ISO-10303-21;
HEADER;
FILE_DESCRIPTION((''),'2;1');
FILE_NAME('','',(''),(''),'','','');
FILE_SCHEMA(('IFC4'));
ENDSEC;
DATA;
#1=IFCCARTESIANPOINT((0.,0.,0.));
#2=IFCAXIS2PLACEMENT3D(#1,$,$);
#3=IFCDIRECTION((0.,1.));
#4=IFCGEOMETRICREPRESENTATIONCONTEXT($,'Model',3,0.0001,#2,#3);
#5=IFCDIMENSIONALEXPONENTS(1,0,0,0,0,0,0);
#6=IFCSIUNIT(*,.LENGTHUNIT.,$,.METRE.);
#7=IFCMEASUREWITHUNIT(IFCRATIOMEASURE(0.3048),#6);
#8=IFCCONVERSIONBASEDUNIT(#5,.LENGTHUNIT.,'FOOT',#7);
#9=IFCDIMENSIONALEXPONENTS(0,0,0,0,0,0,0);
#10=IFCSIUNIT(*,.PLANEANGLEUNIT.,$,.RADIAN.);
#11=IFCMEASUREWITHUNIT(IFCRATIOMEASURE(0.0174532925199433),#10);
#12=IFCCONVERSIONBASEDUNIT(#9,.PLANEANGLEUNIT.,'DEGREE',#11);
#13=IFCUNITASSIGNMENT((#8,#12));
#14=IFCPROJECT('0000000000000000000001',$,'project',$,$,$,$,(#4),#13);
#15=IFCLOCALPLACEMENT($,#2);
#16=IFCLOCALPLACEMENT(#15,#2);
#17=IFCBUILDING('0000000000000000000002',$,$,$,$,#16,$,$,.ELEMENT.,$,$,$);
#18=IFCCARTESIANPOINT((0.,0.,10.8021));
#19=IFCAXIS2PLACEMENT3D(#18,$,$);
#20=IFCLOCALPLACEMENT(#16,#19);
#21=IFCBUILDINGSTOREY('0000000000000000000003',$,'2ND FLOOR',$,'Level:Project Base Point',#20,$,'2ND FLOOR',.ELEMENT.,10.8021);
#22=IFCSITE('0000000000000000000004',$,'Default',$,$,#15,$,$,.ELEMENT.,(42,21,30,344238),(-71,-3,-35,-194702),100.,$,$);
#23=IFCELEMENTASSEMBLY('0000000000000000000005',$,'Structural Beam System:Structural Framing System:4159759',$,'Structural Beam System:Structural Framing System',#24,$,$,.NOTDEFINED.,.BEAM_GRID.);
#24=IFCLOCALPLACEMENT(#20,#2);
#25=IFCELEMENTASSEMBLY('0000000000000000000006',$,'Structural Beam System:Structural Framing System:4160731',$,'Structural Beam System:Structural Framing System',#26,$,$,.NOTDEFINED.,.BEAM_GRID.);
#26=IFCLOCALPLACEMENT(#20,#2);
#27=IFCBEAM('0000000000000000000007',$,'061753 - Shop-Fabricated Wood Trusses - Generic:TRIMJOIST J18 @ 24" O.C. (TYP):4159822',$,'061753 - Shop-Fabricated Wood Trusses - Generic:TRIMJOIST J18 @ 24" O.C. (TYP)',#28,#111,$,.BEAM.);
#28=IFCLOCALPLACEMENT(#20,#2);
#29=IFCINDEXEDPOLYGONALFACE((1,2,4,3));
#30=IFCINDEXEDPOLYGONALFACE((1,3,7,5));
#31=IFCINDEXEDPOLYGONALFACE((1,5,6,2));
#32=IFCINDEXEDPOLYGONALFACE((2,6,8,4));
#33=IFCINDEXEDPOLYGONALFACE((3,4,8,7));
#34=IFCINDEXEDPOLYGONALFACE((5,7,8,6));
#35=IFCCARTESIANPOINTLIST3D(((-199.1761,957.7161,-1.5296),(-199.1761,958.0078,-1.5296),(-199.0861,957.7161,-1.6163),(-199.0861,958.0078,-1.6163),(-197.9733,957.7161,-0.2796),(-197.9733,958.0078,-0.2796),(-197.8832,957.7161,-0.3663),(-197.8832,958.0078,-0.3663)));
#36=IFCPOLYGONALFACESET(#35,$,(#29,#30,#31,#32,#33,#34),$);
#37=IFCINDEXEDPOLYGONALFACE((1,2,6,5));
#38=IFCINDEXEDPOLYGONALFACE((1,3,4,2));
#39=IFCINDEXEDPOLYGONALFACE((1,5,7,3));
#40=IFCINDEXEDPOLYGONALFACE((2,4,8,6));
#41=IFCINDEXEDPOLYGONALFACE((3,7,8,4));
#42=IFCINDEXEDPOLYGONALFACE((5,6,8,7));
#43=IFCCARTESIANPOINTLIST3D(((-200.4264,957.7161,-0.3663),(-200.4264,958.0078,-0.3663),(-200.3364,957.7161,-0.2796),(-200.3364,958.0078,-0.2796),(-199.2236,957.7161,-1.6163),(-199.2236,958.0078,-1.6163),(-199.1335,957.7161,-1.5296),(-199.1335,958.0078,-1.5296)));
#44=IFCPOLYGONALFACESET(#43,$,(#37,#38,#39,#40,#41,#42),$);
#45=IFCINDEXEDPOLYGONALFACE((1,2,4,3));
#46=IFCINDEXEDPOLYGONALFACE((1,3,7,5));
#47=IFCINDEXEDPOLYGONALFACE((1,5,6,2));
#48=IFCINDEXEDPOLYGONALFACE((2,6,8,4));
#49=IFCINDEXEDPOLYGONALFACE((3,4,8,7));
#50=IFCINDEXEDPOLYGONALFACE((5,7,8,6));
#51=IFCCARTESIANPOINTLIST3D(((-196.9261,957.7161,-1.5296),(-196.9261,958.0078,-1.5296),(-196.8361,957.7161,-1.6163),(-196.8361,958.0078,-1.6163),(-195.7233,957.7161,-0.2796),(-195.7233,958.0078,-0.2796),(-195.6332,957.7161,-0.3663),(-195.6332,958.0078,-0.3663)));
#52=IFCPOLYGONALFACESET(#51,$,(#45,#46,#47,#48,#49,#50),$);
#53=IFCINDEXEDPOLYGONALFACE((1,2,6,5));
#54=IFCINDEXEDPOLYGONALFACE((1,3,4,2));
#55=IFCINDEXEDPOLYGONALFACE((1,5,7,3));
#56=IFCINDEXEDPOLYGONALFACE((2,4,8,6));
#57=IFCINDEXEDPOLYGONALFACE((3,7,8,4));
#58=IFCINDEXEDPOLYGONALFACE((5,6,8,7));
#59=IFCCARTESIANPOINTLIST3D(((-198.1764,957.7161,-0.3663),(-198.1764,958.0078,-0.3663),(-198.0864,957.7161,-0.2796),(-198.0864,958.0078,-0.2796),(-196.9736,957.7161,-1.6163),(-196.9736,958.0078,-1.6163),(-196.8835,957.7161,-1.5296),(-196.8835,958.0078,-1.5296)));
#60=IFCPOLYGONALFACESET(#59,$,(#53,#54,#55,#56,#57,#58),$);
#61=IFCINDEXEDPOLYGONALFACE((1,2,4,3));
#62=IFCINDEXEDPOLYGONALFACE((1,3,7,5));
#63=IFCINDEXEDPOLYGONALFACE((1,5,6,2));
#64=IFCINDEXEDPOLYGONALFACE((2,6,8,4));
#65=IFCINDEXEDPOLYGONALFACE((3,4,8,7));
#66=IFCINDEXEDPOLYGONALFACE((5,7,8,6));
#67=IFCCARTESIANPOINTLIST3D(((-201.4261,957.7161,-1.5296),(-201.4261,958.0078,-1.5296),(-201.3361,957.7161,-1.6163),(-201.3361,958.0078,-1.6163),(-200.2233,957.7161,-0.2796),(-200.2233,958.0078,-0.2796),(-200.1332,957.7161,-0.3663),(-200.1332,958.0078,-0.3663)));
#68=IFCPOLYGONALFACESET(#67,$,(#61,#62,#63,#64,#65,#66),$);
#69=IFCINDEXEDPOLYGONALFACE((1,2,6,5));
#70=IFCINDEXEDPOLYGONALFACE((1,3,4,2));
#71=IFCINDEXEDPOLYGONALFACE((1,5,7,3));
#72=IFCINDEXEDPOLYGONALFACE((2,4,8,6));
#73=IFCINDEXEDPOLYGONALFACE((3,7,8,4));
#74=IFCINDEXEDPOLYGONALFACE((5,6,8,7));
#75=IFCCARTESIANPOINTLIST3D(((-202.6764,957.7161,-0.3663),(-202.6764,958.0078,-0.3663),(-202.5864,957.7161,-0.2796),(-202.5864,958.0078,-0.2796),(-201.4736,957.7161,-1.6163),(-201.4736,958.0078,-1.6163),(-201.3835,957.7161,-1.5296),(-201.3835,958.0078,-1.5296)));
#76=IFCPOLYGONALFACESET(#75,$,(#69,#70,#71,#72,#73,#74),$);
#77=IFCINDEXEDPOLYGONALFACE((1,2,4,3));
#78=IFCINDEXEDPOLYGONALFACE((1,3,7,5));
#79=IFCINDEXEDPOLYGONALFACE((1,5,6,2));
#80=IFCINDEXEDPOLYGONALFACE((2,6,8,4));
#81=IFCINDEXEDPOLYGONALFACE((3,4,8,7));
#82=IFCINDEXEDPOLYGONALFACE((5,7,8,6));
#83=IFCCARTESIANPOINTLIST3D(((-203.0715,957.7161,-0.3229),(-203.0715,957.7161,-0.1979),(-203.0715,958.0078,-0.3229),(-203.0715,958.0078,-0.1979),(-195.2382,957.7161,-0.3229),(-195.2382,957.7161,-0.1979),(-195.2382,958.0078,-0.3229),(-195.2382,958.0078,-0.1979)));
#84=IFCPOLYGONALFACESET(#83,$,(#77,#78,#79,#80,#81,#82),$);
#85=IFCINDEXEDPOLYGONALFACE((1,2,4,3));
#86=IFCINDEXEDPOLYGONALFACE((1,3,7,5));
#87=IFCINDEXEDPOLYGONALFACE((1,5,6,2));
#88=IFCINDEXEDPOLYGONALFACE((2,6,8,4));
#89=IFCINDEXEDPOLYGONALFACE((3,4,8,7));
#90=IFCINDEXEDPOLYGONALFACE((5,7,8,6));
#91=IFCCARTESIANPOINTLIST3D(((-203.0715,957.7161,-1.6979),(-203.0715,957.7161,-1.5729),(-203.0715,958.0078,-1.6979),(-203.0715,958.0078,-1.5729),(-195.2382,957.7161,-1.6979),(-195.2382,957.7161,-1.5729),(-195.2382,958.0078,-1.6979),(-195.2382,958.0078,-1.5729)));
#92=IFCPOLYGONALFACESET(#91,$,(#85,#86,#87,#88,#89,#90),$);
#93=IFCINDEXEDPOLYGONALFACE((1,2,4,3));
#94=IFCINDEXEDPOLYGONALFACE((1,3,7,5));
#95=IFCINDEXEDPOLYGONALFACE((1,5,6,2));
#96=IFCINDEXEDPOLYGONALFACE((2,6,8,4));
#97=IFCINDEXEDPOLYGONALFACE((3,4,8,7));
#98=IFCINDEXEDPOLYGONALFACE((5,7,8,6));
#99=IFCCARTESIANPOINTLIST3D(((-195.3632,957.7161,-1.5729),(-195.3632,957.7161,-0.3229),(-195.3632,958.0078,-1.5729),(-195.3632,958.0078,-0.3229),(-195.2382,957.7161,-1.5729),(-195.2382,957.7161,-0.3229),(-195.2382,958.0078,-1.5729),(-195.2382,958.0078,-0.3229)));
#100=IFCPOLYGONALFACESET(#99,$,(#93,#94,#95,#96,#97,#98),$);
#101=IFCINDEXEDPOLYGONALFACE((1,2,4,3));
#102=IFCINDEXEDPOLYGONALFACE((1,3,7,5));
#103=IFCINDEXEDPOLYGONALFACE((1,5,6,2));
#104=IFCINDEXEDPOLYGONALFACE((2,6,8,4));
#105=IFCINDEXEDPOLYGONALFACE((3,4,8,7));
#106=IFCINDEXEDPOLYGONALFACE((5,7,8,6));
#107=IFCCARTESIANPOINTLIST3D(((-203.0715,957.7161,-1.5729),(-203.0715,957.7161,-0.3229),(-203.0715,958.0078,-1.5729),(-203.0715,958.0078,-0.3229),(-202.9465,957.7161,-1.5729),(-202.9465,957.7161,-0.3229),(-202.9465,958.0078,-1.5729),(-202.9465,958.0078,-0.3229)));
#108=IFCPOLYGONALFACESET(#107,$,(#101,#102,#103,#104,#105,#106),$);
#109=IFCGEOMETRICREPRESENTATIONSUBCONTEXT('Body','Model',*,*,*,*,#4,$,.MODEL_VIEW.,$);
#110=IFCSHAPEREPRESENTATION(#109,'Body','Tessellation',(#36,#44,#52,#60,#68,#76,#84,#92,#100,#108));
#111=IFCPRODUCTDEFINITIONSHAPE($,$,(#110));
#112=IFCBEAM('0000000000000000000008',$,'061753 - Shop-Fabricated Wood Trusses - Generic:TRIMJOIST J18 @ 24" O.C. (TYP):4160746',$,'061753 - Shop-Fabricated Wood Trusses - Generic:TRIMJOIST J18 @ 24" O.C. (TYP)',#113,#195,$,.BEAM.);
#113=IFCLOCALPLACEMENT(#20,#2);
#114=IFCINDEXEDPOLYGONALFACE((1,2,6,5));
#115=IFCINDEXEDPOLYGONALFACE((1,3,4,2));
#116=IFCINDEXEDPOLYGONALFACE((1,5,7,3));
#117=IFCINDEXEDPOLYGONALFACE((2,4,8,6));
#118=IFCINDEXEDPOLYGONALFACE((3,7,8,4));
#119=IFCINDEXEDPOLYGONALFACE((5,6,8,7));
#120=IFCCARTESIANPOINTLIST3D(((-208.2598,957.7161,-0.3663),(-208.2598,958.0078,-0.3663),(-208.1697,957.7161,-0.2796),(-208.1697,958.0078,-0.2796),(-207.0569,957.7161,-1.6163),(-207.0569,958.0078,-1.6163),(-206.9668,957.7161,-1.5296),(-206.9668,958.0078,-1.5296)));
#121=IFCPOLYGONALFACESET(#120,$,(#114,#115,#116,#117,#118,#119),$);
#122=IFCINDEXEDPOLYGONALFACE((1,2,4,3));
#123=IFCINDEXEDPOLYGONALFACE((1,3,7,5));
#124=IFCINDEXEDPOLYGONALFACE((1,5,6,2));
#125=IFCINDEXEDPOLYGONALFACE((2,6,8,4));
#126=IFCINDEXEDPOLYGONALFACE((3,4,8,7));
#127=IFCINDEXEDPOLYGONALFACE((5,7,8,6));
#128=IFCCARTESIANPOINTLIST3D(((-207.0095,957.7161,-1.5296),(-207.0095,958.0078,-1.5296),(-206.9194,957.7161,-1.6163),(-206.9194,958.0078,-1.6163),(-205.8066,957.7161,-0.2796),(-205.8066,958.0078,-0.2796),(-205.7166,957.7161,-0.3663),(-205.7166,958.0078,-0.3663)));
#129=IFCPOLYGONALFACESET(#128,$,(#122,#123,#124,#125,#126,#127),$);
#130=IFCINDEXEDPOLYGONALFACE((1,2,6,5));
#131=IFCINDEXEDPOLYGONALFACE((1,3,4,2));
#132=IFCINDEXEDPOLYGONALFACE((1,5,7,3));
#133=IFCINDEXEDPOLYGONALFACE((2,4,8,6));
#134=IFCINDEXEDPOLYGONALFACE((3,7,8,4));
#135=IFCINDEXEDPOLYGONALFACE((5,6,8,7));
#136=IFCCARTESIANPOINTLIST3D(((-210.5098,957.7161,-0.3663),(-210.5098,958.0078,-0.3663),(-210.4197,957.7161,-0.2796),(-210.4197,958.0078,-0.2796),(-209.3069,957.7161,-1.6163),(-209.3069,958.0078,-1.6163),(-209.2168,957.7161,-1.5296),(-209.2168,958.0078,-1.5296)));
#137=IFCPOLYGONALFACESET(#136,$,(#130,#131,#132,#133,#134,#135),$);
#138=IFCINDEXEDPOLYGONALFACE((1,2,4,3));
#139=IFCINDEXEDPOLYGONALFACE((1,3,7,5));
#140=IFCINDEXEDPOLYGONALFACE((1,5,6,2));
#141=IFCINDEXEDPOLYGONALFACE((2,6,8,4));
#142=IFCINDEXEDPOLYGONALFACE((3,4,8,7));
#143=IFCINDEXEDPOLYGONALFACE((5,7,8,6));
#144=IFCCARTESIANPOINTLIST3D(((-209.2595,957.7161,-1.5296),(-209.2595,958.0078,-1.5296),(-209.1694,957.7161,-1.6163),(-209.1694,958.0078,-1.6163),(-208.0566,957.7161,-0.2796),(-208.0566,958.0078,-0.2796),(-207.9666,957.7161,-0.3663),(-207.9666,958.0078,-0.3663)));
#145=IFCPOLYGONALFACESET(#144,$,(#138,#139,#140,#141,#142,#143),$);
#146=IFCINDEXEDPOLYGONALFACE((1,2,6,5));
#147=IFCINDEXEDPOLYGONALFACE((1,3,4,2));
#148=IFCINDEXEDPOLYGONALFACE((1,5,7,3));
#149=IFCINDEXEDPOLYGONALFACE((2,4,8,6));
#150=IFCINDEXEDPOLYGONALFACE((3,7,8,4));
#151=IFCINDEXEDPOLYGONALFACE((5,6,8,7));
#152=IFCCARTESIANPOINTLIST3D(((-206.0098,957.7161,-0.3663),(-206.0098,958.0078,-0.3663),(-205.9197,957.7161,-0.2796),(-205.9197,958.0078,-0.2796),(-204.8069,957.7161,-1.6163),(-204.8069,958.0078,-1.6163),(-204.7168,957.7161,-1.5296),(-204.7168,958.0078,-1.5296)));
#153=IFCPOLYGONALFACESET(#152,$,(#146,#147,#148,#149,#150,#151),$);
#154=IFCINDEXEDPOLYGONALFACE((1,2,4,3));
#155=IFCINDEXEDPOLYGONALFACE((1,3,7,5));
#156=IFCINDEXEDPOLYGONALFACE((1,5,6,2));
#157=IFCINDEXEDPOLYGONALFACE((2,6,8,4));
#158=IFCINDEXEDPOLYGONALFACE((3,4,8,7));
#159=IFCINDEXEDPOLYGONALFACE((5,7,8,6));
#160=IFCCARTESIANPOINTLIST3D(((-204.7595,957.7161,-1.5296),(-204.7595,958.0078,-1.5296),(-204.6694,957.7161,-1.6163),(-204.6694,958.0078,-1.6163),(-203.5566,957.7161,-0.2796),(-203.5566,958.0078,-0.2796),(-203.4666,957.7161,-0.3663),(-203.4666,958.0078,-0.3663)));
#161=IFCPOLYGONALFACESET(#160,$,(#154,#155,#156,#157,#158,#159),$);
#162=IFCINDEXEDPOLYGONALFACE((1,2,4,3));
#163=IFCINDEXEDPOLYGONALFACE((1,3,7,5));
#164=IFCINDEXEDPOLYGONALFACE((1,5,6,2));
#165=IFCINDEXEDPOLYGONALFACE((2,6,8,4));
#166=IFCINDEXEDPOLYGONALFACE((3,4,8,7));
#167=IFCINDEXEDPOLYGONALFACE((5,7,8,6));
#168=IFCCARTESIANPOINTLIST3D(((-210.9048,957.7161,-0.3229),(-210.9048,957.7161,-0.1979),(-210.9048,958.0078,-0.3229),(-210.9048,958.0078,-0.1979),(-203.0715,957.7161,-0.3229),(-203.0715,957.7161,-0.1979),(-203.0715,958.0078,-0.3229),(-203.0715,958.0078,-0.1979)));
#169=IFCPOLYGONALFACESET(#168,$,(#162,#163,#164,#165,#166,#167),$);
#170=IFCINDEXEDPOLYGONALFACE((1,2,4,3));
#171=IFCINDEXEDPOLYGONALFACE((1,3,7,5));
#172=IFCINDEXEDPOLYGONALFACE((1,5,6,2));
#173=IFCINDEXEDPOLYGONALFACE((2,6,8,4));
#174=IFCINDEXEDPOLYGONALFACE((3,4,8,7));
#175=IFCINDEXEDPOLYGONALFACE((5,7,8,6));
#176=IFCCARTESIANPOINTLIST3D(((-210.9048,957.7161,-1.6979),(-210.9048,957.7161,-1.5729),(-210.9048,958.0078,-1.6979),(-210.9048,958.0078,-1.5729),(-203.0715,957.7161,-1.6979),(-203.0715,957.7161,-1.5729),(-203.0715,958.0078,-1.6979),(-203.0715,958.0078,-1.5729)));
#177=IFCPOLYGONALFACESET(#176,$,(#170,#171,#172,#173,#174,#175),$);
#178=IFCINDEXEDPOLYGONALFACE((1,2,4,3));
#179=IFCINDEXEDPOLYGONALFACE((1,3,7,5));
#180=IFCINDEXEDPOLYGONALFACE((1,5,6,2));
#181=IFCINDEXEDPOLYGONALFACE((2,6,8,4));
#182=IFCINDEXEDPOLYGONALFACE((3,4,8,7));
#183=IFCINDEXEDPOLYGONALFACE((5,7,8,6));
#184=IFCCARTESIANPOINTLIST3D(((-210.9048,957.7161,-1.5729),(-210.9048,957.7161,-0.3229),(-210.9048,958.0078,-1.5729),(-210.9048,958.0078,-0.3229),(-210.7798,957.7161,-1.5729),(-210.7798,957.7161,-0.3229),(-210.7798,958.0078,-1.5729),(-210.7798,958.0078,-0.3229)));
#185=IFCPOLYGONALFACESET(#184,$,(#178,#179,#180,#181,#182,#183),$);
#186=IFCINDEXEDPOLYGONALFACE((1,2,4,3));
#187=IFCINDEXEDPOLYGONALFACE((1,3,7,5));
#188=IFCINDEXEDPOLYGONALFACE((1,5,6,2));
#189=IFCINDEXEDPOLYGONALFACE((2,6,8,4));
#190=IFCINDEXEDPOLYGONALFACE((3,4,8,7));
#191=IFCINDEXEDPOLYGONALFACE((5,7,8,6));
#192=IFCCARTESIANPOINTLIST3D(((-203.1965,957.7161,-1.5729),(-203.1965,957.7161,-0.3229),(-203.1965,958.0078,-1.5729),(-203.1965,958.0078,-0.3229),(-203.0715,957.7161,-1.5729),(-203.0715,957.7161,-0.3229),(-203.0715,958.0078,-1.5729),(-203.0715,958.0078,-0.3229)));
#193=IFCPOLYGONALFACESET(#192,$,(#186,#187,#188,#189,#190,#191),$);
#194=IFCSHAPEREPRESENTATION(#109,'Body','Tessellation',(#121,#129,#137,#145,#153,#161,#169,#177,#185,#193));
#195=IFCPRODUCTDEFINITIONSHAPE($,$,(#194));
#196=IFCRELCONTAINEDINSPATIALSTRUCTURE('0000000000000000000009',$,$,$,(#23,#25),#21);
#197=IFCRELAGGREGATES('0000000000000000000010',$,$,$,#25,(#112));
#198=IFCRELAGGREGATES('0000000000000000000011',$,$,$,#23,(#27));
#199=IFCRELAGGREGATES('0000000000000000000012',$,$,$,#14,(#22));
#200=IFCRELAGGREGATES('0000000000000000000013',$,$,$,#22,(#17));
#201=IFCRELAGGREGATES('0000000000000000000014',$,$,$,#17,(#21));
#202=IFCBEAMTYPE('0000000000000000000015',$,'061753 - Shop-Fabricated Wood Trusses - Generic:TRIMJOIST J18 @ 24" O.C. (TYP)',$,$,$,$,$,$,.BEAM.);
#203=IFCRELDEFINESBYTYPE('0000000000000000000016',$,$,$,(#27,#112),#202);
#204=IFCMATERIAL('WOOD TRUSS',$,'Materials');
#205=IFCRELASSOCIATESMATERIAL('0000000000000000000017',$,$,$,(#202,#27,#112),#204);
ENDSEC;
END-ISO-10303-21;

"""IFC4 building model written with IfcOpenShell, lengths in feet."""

from ifc_helpers import new_model, entity, si_unit, converted_unit, direction, frame, frame_2d, origin, origin_2d_with_axis, place, context, subcontext, project, spatial, rectangle, extrude, source, transform, mapped, material, material_profile, profile_set, profile_usage, type_object, type_shapes, element, aggregate, save


model = new_model("IFC4")

# Units and contexts
model_context = context("Model", 3, precision=0.0001, world=origin(), true_north=direction((0.0, 1.0)))
body_context = subcontext(model_context, "Body", "Model", "MODEL_VIEW")
ifc_project = project(units=[converted_unit("LENGTHUNIT", "FOOT", entity("IfcRatioMeasure", 0.3048), si_unit("LENGTHUNIT", "METRE"), dimensions=[1, 0, 0, 0, 0, 0, 0]), converted_unit("PLANEANGLEUNIT", "DEGREE", entity("IfcRatioMeasure", 0.0174532925199433), si_unit("PLANEANGLEUNIT", "RADIAN"), dimensions=[0, 0, 0, 0, 0, 0, 0])], contexts=[model_context])

# Site, building, storey
site_placement = place(None, origin())
site = spatial("IfcSite", under=ifc_project, at=site_placement, Name="Default", CompositionType="ELEMENT", RefLatitude=(42, 21, 30, 344238), RefLongitude=(-71, -3, -35, -194702), RefElevation=100.0)
building_placement = place(site_placement, origin())
building = spatial("IfcBuilding", under=site, at=building_placement, CompositionType="ELEMENT")
storey_placement = place(building_placement, frame((0.0, 0.0, 10.8021)))
storey = spatial("IfcBuildingStorey", under=building, at=storey_placement, Name="2ND FLOOR", ObjectType="Level:Project Base Point", LongName="2ND FLOOR", CompositionType="ELEMENT", Elevation=10.8021)

# Element assembly
ifc_material_1 = material(Name="WOOD TRUSS", Category="Materials")
ifc_material_profile_1 = material_profile(ifc_material_1, rectangle(XDim=1.7347, YDim=0.125, at=frame_2d((0.0, 0.0), x_axis=(1.0, 0.0))), Name="TRIMJOIST J18 @ 24\" O.C. (TYP)")
ifc_material_profile_2 = material_profile(ifc_material_1, rectangle(XDim=1.7347, YDim=0.125, at=frame_2d((0.0, 0.0), x_axis=(1.0, 0.0))), Name="TRIMJOIST J18 @ 24\" O.C. (TYP)")
ifc_material_profile_3 = material_profile(ifc_material_1, rectangle(XDim=1.7347, YDim=0.125, at=frame_2d((0.0, 0.0), x_axis=(1.0, 0.0))), Name="TRIMJOIST J18 @ 24\" O.C. (TYP)")
ifc_material_profile_4 = material_profile(ifc_material_1, rectangle(XDim=1.7347, YDim=0.125, at=frame_2d((0.0, 0.0), x_axis=(1.0, 0.0))), Name="TRIMJOIST J18 @ 24\" O.C. (TYP)")
ifc_material_profile_5 = material_profile(ifc_material_1, rectangle(XDim=1.7347, YDim=0.125, at=frame_2d((0.0, 0.0), x_axis=(1.0, 0.0))), Name="TRIMJOIST J18 @ 24\" O.C. (TYP)")
ifc_material_profile_6 = material_profile(ifc_material_1, rectangle(XDim=1.7347, YDim=0.125, at=frame_2d((0.0, 0.0), x_axis=(1.0, 0.0))), Name="TRIMJOIST J18 @ 24\" O.C. (TYP)")
ifc_material_profile_7 = material_profile(ifc_material_1, rectangle(XDim=1.7347, YDim=0.125, at=frame_2d((0.0, 0.0), x_axis=(1.0, 0.0))), Name="TRIMJOIST J18 @ 24\" O.C. (TYP)")
ifc_material_profile_8 = material_profile(ifc_material_1, rectangle(XDim=1.7347, YDim=0.125, at=frame_2d((0.0, 0.0), x_axis=(1.0, 0.0))), Name="TRIMJOIST J18 @ 24\" O.C. (TYP)")
ifc_material_profile_9 = material_profile(ifc_material_1, rectangle(XDim=1.7347, YDim=0.125, at=frame_2d((0.0, 0.0), x_axis=(1.0, 0.0))), Name="TRIMJOIST J18 @ 24\" O.C. (TYP)")
ifc_material_profile_10 = material_profile(ifc_material_1, rectangle(XDim=1.7347, YDim=0.125, at=origin_2d_with_axis()), Name="TRIMJOIST J18 @ 24\" O.C. (TYP)")
ifc_material_profile_11 = material_profile(ifc_material_1, rectangle(XDim=0.125, YDim=0.2917, at=origin_2d_with_axis()), Name="TRIMJOIST J18 @ 24\" O.C. (TYP)")
ifc_material_profile_12 = material_profile(ifc_material_1, rectangle(XDim=0.125, YDim=0.2917, at=origin_2d_with_axis()), Name="TRIMJOIST J18 @ 24\" O.C. (TYP)")
ifc_material_profile_13 = material_profile(ifc_material_1, rectangle(XDim=1.25, YDim=0.2917, at=origin_2d_with_axis()), Name="TRIMJOIST J18 @ 24\" O.C. (TYP)")
ifc_material_profile_14 = material_profile(ifc_material_1, rectangle(XDim=1.25, YDim=0.2917, at=origin_2d_with_axis()), Name="TRIMJOIST J18 @ 24\" O.C. (TYP)")
ifc_profile_set_1 = profile_set([ifc_material_profile_1, ifc_material_profile_2, ifc_material_profile_3, ifc_material_profile_4, ifc_material_profile_5, ifc_material_profile_6, ifc_material_profile_7, ifc_material_profile_8, ifc_material_profile_9, ifc_material_profile_10, ifc_material_profile_11, ifc_material_profile_12, ifc_material_profile_13, ifc_material_profile_14], Name="TRIMJOIST J18 @ 24\" O.C. (TYP)")
assembly_1_placement = place(storey_placement, origin())
assembly_1 = element("IfcElementAssembly", 1, at=assembly_1_placement, inside=storey, Name="Structural Beam System:Structural Framing System:4159759", ObjectType="Structural Beam System:Structural Framing System", AssemblyPlace="NOTDEFINED", PredefinedType="BEAM_GRID")

# Element assembly
assembly_2_placement = place(storey_placement, origin())
assembly_2 = element("IfcElementAssembly", 2, at=assembly_2_placement, inside=storey, Name="Structural Beam System:Structural Framing System:4160731", ObjectType="Structural Beam System:Structural Framing System", AssemblyPlace="NOTDEFINED", PredefinedType="BEAM_GRID")

# Beams
ifc_profile_usage_1 = profile_usage(ifc_profile_set_1, cardinal=8)
beam_type_1 = type_object("IfcBeamType", Name="061753 - Shop-Fabricated Wood Trusses - Generic:TRIMJOIST J18 @ 24\" O.C. (TYP)", PredefinedType="BEAM", material=ifc_profile_set_1)
shared_shape_1 = source(origin(), body_context, "Body", "SweptSolid", [
    extrude(rectangle(XDim=1.7347, YDim=0.125, at=frame_2d((0.0, 0.0), x_axis=(1.0, 0.0))), frame((0.6251, -0.1458, 0.0), z_axis=(0.0, 1.0, 0.0), x_axis=(0.693383, 0.0, 0.720569)), (0.0, 0.0, 1.0), 0.2917),
    extrude(rectangle(XDim=1.7347, YDim=0.125, at=frame_2d((0.0, 0.0), x_axis=(1.0, 0.0))), frame((-0.6251, -0.1458, 0.0), z_axis=(0.0, 1.0, 0.0), x_axis=(0.693383, 0.0, -0.720569)), (0.0, 0.0, 1.0), 0.2917),
    extrude(rectangle(XDim=1.7347, YDim=0.125, at=frame_2d((0.0, 0.0), x_axis=(1.0, 0.0))), frame((2.8751, -0.1458, 0.0), z_axis=(0.0, 1.0, 0.0), x_axis=(0.693383, 0.0, 0.720569)), (0.0, 0.0, 1.0), 0.2917),
    extrude(rectangle(XDim=1.7347, YDim=0.125, at=frame_2d((0.0, 0.0), x_axis=(1.0, 0.0))), frame((1.6249, -0.1458, 0.0), z_axis=(0.0, 1.0, 0.0), x_axis=(0.693383, 0.0, -0.720569)), (0.0, 0.0, 1.0), 0.2917),
    extrude(rectangle(XDim=1.7347, YDim=0.125, at=frame_2d((0.0, 0.0), x_axis=(1.0, 0.0))), frame((-1.6249, -0.1458, 0.0), z_axis=(0.0, 1.0, 0.0), x_axis=(0.693383, 0.0, 0.720569)), (0.0, 0.0, 1.0), 0.2917),
    extrude(rectangle(XDim=1.7347, YDim=0.125, at=origin_2d_with_axis()), frame((-2.8751, -0.1458, 0.0), z_axis=(0.0, 1.0, 0.0), x_axis=(0.693383, 0.0, -0.720569)), (0.0, 0.0, 1.0), 0.2917),
    extrude(rectangle(XDim=0.125, YDim=0.2917, at=origin_2d_with_axis()), frame((-3.9167, 0.0, 0.6875), z_axis=(1.0, 0.0, 0.0), x_axis=(0.0, 0.0, -1.0)), (0.0, 0.0, 1.0), 7.8333),
    extrude(rectangle(XDim=0.125, YDim=0.2917, at=origin_2d_with_axis()), frame((-3.9167, 0.0, -0.6875), z_axis=(1.0, 0.0, 0.0), x_axis=(0.0, 0.0, -1.0)), (0.0, 0.0, 1.0), 7.8333),
    extrude(rectangle(XDim=1.25, YDim=0.2917, at=origin_2d_with_axis()), frame((3.7917, 0.0, 0.0), z_axis=(1.0, 0.0, 0.0), x_axis=(0.0, 0.0, -1.0)), (0.0, 0.0, 1.0), 0.125),
    extrude(rectangle(XDim=1.25, YDim=0.2917, at=origin_2d_with_axis()), frame((-3.9167, 0.0, 0.0), z_axis=(1.0, 0.0, 0.0), x_axis=(0.0, 0.0, -1.0)), (0.0, 0.0, 1.0), 0.125),
])
type_shapes(beam_type_1, [shared_shape_1])
beam_1_placement = place(assembly_1_placement, frame((-199.1548, 957.8619, -0.9479)))
beam_1 = element("IfcBeam", 3, at=beam_1_placement, type_object=beam_type_1, material=ifc_profile_usage_1, Name="061753 - Shop-Fabricated Wood Trusses - Generic:TRIMJOIST J18 @ 24\" O.C. (TYP):4159822", ObjectType="061753 - Shop-Fabricated Wood Trusses - Generic:TRIMJOIST J18 @ 24\" O.C. (TYP)", PredefinedType="BEAM", context=body_context, shape_type="MappedRepresentation", body=[
    mapped(shared_shape_1, transform((0.0, 0.0, 0.0), scale=1.0)),
])
ifc_profile_usage_2 = profile_usage(ifc_profile_set_1, cardinal=8)
beam_2_placement = place(assembly_2_placement, frame((-206.9882, 957.8619, -0.9479), z_axis=(0.0, 0.0, 1.0), x_axis=(-1.0, 0.0, 0.0)))
beam_2 = element("IfcBeam", 4, at=beam_2_placement, type_object=beam_type_1, material=ifc_profile_usage_2, Name="061753 - Shop-Fabricated Wood Trusses - Generic:TRIMJOIST J18 @ 24\" O.C. (TYP):4160746", ObjectType="061753 - Shop-Fabricated Wood Trusses - Generic:TRIMJOIST J18 @ 24\" O.C. (TYP)", PredefinedType="BEAM", context=body_context, shape_type="MappedRepresentation", body=[
    mapped(shared_shape_1, transform((0.0, 0.0, 0.0), scale=1.0)),
])
aggregate(assembly_2, [beam_2])
aggregate(assembly_1, [beam_1])

save(model, "model.ifc")
